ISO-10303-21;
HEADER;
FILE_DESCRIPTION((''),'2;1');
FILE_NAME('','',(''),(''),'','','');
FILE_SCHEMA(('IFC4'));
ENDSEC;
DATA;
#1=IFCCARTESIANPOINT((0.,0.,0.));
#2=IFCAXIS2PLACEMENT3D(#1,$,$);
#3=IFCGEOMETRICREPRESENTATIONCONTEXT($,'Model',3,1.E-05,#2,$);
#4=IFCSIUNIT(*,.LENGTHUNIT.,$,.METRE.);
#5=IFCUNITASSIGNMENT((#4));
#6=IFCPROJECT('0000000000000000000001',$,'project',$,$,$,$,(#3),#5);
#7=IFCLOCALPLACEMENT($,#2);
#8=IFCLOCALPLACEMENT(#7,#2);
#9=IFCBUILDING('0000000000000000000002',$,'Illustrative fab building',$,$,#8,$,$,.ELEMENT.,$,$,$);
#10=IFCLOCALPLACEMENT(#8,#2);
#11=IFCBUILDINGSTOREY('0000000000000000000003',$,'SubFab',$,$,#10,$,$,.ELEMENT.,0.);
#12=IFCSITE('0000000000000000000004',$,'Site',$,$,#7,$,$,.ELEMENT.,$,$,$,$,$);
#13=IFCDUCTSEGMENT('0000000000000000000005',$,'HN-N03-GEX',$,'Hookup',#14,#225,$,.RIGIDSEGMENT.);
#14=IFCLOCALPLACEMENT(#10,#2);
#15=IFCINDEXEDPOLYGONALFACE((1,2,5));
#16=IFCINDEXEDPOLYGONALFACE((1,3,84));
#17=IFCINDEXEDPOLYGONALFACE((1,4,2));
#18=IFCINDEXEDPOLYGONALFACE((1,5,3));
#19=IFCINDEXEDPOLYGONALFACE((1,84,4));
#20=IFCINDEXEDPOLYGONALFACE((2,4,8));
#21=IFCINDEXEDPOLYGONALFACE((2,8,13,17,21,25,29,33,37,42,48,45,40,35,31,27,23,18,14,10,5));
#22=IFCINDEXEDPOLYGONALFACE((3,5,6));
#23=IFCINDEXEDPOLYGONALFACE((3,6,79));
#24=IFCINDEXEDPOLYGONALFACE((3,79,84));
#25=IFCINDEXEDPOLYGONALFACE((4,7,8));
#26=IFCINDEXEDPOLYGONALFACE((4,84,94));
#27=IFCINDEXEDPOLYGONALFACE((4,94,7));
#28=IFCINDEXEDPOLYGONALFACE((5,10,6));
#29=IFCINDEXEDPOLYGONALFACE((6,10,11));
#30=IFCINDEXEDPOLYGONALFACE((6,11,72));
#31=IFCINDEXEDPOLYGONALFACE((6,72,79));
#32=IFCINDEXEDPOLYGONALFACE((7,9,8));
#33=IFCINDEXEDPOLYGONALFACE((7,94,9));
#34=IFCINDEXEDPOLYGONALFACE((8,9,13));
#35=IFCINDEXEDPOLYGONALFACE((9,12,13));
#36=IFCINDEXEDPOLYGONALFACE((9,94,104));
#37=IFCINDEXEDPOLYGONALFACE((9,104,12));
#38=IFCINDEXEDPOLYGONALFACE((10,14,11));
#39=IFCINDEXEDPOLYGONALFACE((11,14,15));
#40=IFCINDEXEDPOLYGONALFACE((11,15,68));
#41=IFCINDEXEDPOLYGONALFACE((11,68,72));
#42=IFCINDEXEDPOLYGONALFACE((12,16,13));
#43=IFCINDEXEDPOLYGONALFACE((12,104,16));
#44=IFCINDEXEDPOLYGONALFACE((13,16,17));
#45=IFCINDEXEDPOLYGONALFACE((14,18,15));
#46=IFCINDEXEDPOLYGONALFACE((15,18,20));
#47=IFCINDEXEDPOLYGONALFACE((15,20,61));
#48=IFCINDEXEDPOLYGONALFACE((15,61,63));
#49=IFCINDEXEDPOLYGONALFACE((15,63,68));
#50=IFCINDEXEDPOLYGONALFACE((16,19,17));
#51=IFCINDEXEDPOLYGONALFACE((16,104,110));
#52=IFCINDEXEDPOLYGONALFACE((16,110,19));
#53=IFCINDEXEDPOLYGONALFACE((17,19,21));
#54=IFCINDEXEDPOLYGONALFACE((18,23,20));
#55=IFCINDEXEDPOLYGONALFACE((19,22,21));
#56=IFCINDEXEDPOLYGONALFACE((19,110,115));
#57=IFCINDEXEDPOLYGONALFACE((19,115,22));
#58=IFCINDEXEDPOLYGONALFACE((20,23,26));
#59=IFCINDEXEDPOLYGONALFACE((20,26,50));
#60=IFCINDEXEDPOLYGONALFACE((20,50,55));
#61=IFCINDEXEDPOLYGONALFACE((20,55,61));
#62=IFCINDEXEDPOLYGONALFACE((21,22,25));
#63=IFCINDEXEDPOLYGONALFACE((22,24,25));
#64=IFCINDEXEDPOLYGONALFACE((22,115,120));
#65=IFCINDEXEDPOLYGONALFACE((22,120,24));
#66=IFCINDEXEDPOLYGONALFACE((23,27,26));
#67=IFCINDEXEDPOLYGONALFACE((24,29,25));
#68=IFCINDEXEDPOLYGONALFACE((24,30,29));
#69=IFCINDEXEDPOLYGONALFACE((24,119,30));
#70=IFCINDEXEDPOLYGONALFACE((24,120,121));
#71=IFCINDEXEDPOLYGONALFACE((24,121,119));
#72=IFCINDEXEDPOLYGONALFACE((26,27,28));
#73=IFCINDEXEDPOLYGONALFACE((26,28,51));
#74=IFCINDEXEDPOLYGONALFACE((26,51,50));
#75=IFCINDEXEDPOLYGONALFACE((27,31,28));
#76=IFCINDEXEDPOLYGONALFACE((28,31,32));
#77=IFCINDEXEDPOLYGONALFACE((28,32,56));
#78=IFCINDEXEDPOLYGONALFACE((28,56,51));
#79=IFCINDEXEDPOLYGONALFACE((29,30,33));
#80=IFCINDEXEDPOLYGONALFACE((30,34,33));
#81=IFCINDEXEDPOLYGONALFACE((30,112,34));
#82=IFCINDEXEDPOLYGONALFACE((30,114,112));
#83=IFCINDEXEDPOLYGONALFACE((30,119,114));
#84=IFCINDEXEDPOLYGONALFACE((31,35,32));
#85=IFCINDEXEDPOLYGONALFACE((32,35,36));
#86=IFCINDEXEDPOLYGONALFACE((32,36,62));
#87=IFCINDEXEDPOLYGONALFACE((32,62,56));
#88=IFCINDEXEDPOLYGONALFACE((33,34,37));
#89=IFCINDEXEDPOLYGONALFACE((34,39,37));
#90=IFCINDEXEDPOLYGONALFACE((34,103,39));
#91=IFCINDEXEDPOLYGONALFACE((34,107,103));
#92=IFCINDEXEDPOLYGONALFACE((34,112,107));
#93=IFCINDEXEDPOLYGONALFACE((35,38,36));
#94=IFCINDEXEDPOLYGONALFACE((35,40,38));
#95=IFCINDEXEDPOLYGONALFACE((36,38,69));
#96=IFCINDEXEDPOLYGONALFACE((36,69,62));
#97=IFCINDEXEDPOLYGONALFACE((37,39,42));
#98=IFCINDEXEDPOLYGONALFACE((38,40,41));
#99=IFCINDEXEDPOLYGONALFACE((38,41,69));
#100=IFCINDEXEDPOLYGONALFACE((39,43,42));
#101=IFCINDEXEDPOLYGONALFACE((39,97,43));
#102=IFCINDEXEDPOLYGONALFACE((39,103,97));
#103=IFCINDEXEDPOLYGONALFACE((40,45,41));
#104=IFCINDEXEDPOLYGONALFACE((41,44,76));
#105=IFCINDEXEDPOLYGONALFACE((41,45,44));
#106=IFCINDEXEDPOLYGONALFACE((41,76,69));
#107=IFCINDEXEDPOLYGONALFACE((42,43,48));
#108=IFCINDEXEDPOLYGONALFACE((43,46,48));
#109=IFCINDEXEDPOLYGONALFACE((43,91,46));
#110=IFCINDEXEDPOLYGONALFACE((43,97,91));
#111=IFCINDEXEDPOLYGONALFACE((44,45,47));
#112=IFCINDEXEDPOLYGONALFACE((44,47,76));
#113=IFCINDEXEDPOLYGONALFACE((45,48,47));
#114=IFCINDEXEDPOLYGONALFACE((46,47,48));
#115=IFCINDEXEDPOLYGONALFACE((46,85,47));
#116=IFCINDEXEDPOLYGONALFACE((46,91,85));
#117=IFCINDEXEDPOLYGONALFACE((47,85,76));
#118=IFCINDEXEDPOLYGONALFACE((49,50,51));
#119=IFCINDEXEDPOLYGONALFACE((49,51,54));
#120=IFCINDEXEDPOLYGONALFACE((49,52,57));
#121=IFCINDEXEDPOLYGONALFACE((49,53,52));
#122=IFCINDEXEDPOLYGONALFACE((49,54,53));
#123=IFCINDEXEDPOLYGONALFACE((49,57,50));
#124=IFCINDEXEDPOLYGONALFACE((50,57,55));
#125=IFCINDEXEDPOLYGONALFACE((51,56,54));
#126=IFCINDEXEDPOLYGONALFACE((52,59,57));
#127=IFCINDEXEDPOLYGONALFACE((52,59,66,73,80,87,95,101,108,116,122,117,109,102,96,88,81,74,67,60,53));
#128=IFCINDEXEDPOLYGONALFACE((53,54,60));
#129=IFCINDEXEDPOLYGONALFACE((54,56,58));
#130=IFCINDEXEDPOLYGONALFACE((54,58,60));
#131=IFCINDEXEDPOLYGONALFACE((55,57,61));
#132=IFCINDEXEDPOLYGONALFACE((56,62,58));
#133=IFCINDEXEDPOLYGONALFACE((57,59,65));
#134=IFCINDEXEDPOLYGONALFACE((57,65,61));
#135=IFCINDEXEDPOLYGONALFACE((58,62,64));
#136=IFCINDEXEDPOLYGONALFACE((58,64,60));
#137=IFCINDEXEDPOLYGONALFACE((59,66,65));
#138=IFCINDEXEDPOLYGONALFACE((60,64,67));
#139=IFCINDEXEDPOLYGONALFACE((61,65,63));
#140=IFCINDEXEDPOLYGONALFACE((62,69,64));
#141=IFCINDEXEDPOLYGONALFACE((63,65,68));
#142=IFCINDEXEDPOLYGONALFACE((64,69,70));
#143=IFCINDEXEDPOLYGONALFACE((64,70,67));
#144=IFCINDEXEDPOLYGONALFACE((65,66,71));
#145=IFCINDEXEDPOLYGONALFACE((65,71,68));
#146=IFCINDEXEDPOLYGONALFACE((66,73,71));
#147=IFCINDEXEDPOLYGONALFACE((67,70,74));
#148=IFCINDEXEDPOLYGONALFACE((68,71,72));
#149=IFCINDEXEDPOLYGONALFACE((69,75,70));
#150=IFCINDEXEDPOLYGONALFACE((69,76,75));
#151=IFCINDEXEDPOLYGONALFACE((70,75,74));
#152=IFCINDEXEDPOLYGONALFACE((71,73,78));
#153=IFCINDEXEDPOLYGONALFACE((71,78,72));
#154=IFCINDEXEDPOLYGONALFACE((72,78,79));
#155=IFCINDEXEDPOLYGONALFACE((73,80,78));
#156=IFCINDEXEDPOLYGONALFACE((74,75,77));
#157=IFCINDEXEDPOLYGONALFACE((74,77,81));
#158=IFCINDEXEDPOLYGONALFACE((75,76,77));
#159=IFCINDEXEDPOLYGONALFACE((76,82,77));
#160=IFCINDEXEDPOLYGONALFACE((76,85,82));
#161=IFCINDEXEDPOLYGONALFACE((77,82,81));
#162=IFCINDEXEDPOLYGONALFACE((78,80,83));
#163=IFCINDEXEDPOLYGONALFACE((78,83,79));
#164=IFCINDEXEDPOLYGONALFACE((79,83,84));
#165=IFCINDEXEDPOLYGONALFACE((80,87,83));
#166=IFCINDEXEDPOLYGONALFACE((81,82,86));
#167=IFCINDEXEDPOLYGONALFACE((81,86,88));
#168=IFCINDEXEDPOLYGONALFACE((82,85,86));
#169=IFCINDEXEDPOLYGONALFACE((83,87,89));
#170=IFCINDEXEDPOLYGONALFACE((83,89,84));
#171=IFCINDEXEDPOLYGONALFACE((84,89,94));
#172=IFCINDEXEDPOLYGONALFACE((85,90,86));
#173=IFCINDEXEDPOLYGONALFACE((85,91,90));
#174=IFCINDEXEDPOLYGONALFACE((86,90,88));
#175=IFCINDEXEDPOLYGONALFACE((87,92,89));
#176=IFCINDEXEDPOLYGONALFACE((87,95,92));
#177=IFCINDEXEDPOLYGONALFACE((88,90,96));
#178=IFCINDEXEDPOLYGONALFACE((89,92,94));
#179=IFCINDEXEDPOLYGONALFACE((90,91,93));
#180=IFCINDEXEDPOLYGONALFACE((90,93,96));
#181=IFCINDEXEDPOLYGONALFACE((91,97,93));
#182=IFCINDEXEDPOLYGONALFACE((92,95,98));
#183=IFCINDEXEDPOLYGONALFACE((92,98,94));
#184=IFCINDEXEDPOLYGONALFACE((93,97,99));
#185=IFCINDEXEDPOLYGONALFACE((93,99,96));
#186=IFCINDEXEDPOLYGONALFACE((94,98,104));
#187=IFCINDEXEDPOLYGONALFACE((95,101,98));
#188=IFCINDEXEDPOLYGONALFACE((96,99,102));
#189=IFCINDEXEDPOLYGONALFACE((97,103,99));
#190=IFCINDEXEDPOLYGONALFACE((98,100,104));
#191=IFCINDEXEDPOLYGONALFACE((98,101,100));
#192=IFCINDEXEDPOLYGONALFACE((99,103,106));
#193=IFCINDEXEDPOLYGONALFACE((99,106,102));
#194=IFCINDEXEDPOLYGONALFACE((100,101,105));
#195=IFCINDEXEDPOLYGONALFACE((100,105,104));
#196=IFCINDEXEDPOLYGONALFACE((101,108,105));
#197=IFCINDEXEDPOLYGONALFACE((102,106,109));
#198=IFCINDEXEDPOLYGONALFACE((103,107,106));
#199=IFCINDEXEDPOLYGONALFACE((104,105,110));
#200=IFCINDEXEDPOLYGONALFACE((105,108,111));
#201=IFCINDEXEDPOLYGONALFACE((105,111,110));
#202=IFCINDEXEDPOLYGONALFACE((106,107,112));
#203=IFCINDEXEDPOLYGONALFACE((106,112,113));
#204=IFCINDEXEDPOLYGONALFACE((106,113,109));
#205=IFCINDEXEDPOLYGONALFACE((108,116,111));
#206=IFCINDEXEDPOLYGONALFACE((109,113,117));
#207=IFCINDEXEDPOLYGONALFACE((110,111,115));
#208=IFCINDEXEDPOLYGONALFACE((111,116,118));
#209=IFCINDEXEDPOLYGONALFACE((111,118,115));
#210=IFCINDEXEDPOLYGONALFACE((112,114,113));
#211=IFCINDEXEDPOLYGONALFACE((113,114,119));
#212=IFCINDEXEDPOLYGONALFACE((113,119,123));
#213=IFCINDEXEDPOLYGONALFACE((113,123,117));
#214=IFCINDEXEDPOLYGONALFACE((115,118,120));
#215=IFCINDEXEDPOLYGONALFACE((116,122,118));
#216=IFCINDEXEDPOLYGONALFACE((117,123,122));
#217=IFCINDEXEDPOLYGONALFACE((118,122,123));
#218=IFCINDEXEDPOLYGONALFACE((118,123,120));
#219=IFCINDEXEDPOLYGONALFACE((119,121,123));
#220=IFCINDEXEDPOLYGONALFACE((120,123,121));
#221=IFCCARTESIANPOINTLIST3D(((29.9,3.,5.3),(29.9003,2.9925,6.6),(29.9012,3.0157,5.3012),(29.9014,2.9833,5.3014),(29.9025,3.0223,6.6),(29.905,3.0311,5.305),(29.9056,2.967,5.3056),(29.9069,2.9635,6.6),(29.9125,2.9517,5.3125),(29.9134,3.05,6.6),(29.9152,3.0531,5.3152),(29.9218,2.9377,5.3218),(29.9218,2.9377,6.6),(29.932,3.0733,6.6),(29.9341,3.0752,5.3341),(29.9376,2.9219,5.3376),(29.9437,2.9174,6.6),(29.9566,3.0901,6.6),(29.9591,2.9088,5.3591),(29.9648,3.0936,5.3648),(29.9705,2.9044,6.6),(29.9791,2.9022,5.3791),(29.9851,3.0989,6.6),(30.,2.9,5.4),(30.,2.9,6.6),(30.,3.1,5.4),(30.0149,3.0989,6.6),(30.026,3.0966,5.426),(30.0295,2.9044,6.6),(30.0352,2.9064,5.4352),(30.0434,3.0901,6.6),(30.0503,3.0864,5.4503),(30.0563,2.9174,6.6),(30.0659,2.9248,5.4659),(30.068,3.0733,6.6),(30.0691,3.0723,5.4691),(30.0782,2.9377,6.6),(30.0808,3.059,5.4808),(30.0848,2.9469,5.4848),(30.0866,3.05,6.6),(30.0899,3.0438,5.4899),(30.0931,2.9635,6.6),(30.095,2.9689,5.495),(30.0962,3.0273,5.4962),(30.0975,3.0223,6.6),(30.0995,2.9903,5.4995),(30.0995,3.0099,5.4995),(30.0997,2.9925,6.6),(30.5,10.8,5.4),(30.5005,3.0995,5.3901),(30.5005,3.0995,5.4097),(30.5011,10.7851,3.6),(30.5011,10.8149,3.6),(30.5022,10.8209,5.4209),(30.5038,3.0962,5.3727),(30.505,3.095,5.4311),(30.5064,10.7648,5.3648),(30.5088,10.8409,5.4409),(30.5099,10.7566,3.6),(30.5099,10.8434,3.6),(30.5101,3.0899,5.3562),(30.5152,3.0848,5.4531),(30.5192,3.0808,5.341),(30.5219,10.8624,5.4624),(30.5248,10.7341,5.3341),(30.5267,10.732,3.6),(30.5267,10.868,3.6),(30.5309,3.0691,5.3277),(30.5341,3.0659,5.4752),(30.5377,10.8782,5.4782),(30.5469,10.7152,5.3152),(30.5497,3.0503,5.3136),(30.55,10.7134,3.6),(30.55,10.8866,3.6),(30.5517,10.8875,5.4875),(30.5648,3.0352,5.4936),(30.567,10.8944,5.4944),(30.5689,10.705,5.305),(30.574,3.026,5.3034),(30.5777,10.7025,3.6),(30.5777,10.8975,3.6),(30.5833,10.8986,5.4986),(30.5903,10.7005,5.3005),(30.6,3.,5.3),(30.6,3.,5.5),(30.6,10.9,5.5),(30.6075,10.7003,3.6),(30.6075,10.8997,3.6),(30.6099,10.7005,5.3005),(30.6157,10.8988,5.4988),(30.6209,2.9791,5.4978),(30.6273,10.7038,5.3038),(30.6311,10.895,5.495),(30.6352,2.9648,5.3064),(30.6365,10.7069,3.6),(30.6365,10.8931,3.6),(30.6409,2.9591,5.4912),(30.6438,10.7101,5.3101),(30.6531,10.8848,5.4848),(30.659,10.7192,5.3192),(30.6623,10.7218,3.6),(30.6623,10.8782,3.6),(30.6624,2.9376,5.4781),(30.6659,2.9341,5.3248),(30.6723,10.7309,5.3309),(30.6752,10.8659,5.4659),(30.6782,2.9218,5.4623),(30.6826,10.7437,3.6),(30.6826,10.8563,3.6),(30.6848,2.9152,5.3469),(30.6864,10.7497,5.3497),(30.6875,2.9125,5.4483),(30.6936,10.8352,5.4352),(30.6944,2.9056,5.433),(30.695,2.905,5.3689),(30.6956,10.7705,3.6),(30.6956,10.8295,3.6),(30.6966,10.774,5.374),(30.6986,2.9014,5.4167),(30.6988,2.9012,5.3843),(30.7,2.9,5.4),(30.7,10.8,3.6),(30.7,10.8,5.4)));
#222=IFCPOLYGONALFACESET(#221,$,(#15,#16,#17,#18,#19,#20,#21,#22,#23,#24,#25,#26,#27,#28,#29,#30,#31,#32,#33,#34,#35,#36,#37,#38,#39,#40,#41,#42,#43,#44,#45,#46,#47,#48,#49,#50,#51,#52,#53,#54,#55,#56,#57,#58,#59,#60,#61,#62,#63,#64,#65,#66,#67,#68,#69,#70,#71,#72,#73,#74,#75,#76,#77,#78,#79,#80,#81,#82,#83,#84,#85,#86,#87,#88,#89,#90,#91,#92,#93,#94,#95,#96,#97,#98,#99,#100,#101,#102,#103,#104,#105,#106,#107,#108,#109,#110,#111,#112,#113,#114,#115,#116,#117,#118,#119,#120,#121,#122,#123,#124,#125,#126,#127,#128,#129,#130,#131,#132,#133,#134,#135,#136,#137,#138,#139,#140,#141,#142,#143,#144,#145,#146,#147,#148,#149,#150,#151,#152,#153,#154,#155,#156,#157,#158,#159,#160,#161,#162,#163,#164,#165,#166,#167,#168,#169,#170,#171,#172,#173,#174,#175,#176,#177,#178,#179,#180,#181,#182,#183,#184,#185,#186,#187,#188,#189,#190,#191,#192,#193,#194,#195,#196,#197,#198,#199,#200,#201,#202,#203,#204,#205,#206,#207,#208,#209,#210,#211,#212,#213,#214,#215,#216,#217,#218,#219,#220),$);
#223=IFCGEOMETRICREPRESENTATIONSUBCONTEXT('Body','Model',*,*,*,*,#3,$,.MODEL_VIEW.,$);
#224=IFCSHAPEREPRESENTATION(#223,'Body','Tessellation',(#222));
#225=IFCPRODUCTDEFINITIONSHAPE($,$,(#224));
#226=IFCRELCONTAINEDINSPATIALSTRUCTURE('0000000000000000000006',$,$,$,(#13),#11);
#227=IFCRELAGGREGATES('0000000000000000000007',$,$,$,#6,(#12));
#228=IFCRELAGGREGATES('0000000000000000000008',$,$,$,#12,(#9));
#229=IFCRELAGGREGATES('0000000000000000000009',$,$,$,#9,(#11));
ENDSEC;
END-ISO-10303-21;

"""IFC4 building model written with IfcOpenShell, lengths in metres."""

from ifc_helpers import new_model, entity, si_unit, origin, place, context, subcontext, project, spatial, element, save


model = new_model("IFC4")

# Units and contexts
model_context = context("Model", 3, precision=1e-05, world=origin())
body_context = subcontext(model_context, "Body", "Model", "MODEL_VIEW")
ifc_project = project(units=[si_unit("LENGTHUNIT", "METRE")], contexts=[model_context])

# Site, building, storey
site_placement = place(None, origin())
site = spatial("IfcSite", under=ifc_project, at=site_placement, Name="Site", CompositionType="ELEMENT")
building_placement = place(site_placement, origin())
building = spatial("IfcBuilding", under=site, at=building_placement, Name="Illustrative fab building", CompositionType="ELEMENT")
storey_placement = place(building_placement, origin())
storey = spatial("IfcBuildingStorey", under=building, at=storey_placement, Name="SubFab", CompositionType="ELEMENT", Elevation=0.0)

# Duct segment
duct_segment_1_placement = place(storey_placement, origin())
element("IfcDuctSegment", 1, at=duct_segment_1_placement, inside=storey, Name="HN-N03-GEX", ObjectType="Hookup", PredefinedType="RIGIDSEGMENT", context=body_context, shape_type="AdvancedSweptSolid", body=[
    entity("IfcSweptDiskSolid", entity("IfcPolyline", [entity("IfcCartesianPoint", [30.6, 10.8, 3.6]), entity("IfcCartesianPoint", [30.6, 10.8, 5.4]), entity("IfcCartesianPoint", [30.6, 3.0, 5.4]), entity("IfcCartesianPoint", [30.0, 3.0, 5.4]), entity("IfcCartesianPoint", [30.0, 3.0, 6.6])]), 0.1),
])

save(model, "model.ifc")
